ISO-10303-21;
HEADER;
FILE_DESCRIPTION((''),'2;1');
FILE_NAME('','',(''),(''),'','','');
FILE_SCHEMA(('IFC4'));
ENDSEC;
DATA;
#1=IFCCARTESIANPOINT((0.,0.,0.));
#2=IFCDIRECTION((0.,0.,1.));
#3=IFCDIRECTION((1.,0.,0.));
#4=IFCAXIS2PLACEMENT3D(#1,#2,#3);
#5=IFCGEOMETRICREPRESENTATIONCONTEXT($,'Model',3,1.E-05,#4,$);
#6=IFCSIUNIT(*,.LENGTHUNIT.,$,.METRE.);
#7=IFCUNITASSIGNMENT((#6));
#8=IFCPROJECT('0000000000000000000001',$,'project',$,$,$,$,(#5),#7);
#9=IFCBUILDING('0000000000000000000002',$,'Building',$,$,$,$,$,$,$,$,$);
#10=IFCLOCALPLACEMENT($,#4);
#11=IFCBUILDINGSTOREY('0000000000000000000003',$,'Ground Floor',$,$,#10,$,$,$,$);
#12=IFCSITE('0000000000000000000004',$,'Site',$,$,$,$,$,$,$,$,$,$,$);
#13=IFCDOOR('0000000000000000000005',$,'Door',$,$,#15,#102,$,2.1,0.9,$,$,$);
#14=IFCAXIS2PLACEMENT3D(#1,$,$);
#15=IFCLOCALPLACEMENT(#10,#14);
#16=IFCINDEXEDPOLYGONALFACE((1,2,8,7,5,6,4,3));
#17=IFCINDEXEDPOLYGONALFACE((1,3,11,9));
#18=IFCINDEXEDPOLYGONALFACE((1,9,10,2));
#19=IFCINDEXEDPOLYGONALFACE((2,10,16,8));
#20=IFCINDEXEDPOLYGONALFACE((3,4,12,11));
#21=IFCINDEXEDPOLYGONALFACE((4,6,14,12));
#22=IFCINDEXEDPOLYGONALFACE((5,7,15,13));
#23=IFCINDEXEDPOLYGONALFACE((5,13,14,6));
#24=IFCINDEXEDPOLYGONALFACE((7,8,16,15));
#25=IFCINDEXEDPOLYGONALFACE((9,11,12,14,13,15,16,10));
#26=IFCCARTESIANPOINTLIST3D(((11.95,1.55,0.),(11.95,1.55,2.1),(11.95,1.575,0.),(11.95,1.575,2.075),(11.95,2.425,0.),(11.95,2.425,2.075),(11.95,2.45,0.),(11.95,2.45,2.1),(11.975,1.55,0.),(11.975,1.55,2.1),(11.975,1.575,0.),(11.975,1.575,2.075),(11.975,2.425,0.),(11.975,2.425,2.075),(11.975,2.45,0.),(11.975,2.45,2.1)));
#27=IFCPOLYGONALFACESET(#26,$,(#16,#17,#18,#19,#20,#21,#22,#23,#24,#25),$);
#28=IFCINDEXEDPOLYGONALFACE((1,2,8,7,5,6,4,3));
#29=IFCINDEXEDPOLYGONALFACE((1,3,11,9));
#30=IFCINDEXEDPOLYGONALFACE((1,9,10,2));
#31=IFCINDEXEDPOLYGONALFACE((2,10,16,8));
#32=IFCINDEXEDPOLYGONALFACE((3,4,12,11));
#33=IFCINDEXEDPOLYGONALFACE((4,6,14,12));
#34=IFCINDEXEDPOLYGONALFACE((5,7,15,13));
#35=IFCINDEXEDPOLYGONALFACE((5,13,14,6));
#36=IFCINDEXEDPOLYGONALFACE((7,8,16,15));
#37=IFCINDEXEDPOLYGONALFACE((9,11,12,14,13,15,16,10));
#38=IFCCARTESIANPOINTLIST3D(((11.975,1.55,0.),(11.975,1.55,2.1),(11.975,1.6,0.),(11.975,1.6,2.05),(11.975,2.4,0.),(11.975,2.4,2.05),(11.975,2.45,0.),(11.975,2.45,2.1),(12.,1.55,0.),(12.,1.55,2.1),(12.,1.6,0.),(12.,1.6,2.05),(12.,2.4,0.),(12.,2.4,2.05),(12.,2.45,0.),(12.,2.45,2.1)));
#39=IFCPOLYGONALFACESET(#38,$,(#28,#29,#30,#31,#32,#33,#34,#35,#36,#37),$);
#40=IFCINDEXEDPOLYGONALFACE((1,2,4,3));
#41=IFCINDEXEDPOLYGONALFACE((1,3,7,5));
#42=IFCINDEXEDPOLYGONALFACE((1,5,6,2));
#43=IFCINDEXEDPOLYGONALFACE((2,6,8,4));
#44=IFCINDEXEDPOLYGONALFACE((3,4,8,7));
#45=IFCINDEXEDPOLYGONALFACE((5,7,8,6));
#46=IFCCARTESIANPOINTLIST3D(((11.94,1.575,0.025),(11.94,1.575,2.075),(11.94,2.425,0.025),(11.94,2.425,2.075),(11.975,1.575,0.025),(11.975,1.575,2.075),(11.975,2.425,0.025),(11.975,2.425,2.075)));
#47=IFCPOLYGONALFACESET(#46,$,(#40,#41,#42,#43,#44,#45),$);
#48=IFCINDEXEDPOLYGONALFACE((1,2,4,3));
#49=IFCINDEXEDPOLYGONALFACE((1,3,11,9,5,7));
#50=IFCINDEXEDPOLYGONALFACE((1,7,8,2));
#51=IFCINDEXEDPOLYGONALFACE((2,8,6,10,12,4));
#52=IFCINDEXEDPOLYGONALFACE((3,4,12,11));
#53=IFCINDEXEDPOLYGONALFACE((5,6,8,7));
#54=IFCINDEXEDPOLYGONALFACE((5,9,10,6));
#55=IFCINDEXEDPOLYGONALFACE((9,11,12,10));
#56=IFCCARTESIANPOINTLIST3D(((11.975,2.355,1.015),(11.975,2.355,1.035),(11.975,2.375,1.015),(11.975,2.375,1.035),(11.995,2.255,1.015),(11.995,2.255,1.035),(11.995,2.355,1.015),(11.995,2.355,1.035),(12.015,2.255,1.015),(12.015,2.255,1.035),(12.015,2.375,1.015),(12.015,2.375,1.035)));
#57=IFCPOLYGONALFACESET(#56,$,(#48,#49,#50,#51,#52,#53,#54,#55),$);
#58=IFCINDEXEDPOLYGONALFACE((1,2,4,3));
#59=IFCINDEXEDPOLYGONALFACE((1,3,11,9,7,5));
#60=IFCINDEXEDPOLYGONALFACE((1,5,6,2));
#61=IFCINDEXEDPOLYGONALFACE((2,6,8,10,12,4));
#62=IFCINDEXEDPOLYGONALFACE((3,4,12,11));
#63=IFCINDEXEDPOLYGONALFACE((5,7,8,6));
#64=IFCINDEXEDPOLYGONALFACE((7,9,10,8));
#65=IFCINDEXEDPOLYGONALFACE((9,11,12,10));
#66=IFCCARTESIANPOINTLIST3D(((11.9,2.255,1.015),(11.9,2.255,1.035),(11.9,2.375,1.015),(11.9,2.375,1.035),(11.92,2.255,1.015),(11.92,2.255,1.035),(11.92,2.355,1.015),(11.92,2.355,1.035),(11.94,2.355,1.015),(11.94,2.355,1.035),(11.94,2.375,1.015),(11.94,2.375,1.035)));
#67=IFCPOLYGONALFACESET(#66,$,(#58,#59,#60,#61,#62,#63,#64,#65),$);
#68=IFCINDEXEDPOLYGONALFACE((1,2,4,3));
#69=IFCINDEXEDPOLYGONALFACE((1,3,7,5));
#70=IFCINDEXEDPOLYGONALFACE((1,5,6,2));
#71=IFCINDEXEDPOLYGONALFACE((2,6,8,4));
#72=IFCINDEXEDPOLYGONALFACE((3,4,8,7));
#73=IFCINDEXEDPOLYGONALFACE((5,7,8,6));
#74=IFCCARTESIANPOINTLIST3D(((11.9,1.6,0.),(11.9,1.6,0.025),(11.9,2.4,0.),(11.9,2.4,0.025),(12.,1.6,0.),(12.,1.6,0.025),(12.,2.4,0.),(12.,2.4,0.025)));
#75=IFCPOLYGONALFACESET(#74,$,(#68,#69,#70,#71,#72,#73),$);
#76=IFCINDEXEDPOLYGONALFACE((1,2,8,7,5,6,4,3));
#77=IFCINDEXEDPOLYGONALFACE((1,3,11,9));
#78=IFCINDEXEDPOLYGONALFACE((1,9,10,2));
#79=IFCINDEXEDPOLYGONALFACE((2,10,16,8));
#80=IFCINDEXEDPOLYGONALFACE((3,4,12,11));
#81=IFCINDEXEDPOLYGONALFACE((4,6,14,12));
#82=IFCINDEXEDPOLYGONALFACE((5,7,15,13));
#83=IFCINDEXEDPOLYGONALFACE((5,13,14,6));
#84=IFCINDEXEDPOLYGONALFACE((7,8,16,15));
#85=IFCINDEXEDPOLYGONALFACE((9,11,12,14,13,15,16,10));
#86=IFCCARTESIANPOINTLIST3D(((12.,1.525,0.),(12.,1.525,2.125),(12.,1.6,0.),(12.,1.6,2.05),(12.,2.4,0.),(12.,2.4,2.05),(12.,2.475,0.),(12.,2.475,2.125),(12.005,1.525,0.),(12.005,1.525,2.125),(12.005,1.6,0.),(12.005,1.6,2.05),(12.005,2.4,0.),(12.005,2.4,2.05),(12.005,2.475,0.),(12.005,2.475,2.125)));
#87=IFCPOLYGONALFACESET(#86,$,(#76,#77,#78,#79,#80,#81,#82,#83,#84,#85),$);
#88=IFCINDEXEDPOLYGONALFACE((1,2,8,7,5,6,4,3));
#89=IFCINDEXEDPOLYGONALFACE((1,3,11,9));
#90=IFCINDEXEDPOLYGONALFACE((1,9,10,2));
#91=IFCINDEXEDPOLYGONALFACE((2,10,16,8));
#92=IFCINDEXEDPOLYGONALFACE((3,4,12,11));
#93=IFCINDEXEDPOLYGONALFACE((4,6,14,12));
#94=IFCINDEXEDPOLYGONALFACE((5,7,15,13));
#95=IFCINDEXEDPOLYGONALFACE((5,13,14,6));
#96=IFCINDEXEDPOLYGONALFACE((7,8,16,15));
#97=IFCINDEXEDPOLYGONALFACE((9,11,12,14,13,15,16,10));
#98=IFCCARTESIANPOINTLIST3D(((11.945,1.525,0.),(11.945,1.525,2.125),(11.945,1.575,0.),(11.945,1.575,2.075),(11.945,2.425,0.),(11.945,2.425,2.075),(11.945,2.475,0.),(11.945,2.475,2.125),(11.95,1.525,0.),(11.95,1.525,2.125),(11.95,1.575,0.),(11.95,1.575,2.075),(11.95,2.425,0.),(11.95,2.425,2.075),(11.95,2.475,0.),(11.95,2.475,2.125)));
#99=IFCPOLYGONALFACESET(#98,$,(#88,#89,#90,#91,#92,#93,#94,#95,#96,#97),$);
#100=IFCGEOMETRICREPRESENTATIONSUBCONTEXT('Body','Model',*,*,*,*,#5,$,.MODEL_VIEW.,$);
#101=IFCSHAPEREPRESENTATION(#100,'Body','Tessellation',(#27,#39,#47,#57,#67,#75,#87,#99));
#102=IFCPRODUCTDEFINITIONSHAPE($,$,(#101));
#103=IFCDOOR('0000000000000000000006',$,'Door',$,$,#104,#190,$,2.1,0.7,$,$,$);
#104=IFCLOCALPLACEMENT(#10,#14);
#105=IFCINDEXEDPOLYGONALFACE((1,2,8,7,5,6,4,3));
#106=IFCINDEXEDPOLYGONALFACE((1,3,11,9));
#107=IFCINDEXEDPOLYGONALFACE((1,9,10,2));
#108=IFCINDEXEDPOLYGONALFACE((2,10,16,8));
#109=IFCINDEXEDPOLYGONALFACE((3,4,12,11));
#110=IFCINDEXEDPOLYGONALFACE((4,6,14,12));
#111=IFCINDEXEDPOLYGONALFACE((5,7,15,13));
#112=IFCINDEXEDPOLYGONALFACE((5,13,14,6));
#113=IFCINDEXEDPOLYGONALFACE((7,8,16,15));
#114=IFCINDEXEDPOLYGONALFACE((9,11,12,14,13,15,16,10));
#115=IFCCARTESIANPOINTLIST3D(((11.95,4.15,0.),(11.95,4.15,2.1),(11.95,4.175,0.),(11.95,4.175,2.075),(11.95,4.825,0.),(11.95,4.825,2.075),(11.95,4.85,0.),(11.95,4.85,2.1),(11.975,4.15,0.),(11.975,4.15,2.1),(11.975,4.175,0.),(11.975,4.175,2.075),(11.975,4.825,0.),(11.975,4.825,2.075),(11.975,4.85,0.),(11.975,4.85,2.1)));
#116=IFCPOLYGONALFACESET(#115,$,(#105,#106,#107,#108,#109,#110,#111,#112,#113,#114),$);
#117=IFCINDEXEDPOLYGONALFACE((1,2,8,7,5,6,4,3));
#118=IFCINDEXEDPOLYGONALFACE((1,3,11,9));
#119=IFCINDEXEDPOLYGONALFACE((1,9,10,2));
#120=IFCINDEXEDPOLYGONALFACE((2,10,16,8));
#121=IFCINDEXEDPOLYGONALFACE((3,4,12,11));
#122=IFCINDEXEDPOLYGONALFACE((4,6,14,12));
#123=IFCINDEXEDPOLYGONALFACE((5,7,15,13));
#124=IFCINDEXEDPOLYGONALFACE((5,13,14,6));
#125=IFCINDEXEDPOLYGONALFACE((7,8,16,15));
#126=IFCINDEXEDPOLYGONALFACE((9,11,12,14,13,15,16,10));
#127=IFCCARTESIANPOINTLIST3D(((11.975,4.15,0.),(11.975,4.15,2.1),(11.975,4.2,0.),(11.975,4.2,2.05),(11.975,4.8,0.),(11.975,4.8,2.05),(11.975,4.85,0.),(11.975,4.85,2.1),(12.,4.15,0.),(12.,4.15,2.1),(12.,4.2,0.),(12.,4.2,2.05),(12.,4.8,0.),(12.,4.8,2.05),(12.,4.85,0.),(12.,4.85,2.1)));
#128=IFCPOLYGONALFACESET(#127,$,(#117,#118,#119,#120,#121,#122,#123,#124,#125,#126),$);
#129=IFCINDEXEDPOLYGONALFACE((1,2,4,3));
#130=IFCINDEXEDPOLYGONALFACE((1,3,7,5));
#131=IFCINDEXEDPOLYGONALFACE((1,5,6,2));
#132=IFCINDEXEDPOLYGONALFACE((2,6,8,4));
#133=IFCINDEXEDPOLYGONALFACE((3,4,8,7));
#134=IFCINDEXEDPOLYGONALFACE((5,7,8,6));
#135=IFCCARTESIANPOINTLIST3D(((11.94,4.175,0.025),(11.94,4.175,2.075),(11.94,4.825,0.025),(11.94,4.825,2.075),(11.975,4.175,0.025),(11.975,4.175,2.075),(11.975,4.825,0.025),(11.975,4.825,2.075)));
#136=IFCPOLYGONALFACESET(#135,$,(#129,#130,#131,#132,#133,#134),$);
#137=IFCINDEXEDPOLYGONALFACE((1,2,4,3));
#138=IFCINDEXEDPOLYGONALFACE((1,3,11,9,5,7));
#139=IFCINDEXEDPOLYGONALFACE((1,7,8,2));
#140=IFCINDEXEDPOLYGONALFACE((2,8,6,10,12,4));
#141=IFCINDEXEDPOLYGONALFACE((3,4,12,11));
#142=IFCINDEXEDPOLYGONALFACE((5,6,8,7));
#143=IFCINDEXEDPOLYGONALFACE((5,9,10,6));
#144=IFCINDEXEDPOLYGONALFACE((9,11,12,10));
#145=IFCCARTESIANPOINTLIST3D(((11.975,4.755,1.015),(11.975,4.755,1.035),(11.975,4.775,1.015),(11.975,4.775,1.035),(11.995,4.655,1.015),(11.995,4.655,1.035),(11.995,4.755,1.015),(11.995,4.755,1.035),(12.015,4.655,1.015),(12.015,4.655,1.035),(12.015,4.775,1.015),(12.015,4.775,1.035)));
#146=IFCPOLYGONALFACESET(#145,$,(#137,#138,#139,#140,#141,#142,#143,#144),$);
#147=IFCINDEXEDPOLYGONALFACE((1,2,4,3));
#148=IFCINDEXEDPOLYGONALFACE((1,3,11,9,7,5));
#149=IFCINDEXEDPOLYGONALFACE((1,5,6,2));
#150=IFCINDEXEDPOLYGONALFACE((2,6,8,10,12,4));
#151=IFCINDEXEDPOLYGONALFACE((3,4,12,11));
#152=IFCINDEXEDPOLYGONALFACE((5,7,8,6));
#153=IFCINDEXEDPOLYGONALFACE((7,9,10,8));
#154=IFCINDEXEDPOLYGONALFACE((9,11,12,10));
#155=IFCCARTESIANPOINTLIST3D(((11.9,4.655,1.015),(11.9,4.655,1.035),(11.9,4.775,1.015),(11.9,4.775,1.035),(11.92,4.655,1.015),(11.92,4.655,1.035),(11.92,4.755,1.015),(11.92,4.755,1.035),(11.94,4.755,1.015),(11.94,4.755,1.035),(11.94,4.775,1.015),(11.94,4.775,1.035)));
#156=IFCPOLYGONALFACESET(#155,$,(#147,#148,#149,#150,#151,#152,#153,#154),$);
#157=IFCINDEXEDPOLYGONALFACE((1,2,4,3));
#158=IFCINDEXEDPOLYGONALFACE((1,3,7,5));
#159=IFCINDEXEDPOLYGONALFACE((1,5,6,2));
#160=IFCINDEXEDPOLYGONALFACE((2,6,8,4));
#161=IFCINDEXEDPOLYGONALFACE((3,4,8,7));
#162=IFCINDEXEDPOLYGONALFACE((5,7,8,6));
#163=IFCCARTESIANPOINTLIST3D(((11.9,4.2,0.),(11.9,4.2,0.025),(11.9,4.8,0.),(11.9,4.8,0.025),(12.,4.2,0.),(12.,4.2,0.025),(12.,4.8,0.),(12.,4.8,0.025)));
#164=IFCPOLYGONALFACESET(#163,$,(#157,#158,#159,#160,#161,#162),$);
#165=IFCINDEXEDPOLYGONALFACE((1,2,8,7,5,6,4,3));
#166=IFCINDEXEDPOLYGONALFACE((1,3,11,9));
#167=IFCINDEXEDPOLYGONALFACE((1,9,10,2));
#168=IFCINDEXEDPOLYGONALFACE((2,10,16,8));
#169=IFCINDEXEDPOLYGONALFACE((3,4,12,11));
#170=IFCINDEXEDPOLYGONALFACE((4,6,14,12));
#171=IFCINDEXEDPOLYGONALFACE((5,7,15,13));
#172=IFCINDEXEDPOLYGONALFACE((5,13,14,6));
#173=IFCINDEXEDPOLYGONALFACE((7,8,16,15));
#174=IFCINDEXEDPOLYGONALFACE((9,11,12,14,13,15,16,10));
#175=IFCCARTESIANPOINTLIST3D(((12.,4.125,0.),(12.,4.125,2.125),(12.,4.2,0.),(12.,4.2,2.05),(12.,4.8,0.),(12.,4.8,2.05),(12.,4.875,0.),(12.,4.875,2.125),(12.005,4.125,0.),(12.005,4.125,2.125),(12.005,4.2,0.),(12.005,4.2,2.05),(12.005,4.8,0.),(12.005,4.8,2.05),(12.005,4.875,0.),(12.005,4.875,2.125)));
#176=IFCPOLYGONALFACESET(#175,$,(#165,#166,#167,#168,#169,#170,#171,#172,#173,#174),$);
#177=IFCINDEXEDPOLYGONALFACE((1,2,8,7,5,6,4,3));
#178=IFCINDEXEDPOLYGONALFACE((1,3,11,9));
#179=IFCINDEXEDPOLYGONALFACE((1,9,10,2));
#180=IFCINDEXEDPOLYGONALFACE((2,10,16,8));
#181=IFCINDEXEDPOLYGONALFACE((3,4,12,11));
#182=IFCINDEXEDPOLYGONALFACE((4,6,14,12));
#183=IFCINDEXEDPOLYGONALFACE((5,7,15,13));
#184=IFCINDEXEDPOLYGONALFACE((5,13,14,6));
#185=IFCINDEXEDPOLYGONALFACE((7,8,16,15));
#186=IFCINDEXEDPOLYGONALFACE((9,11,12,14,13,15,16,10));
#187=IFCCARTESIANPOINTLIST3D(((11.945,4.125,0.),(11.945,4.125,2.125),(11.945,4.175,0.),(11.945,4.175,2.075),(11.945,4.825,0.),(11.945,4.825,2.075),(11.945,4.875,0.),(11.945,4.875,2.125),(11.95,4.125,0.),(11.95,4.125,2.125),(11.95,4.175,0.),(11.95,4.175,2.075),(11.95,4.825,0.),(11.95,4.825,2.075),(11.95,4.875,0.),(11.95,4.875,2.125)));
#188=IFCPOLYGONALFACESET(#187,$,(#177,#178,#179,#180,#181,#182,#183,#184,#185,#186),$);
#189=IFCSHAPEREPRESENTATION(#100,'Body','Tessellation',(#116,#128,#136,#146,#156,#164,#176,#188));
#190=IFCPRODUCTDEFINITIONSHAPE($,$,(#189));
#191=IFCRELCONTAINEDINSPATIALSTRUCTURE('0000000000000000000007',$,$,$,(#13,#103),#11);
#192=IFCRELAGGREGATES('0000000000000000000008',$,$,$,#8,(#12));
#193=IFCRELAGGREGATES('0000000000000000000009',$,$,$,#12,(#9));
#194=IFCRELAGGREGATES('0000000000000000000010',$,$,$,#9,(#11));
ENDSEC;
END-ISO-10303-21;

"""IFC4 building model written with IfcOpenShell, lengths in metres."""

from ifc_helpers import new_model, si_unit, frame, origin_with_axes, place, context, subcontext, project, spatial, line, indexed_curve, outline, extrude, element, save


model = new_model("IFC4")

# Units and contexts
model_context = context("Model", 3, precision=1e-05, world=origin_with_axes())
body_context = subcontext(model_context, "Body", "Model", "MODEL_VIEW")
ifc_project = project(units=[si_unit("LENGTHUNIT", "METRE")], contexts=[model_context])

# Site, building, storey
site = spatial("IfcSite", under=ifc_project, Name="Site")
building = spatial("IfcBuilding", under=site, Name="Building")
storey_placement = place(None, origin_with_axes())
storey = spatial("IfcBuildingStorey", under=building, at=storey_placement, Name="Ground Floor")

# Doors
door_1_placement = place(storey_placement, frame((12.0, 1.55, 0.0), z_axis=(0.0, 0.0, 1.0), x_axis=(0.0, 1.0, 0.0)))
element("IfcDoor", 1, at=door_1_placement, inside=storey, Name="Door", OverallHeight=2.1, OverallWidth=0.9, context=body_context, shape_type="SweptSolid", body=[
    extrude(outline(indexed_curve([(0.0, 0.0), (0.0, 2.1), (0.9, 2.1), (0.9, 0.0), (0.875, 0.0), (0.875, 2.075), (0.025, 2.075), (0.025, 0.0)], segments=[line(1, 2, 3, 4, 5, 6, 7, 8, 1)])), frame((0.0, 0.025, 0.0), z_axis=(0.0, -1.0, 0.0), x_axis=(1.0, 0.0, 0.0)), (0.0, 0.0, -1.0), 0.025),
    extrude(outline(indexed_curve([(0.0, 0.0), (0.0, 2.1), (0.9, 2.1), (0.9, 0.0), (0.85, 0.0), (0.85, 2.05), (0.05, 2.05), (0.05, 0.0)], segments=[line(1, 2, 3, 4, 5, 6, 7, 8, 1)])), frame((0.0, 0.0, 0.0), z_axis=(0.0, -1.0, 0.0), x_axis=(1.0, 0.0, 0.0)), (0.0, 0.0, -1.0), 0.025),
    extrude(outline(indexed_curve([(0.0, 0.0), (0.85, 0.0), (0.85, 0.035), (0.0, 0.035)], segments=[line(1, 2, 3, 4, 1)])), frame((0.025, 0.025, 0.025), z_axis=(0.0, 0.0, 1.0), x_axis=(1.0, 0.0, 0.0)), (0.0, 0.0, 1.0), 2.05),
    extrude(outline(indexed_curve([(0.0, 0.0), (0.0, -0.04), (-0.12, -0.04), (-0.12, -0.02), (-0.02, -0.02), (-0.02, 0.0)], segments=[line(1, 2, 3, 4, 5, 6, 1)])), frame((0.825, 0.025, 1.015), z_axis=(0.0, 0.0, 1.0), x_axis=(1.0, 0.0, 0.0)), (0.0, 0.0, 1.0), 0.02),
    extrude(outline(indexed_curve([(0.0, 0.0), (0.0, 0.04), (-0.12, 0.04), (-0.12, 0.02), (-0.02, 0.02), (-0.02, 0.0)], segments=[line(1, 2, 3, 4, 5, 6, 1)])), frame((0.825, 0.06, 1.015), z_axis=(0.0, 0.0, 1.0), x_axis=(1.0, 0.0, 0.0)), (0.0, 0.0, 1.0), 0.02),
    extrude(outline(indexed_curve([(0.0, 0.0), (0.8, 0.0), (0.8, 0.1), (0.0, 0.1)], segments=[line(1, 2, 3, 4, 1)])), frame((0.05, 0.0, 0.0), z_axis=(0.0, 0.0, 1.0), x_axis=(1.0, 0.0, 0.0)), (0.0, 0.0, 1.0), 0.025),
    extrude(outline(indexed_curve([(0.0, 0.0), (0.0, 2.125), (0.95, 2.125), (0.95, 0.0), (0.875, 0.0), (0.875, 2.05), (0.075, 2.05), (0.075, 0.0)], segments=[line(1, 2, 3, 4, 5, 6, 7, 8, 1)])), frame((-0.025, -0.005, 0.0), z_axis=(0.0, -1.0, 0.0), x_axis=(1.0, 0.0, 0.0)), (0.0, 0.0, -1.0), 0.005),
    extrude(outline(indexed_curve([(0.0, 0.0), (0.0, 2.125), (0.95, 2.125), (0.95, 0.0), (0.9, 0.0), (0.9, 2.075), (0.05, 2.075), (0.05, 0.0)], segments=[line(1, 2, 3, 4, 5, 6, 7, 8, 1)])), frame((-0.025, 0.05, 0.0), z_axis=(0.0, -1.0, 0.0), x_axis=(1.0, 0.0, 0.0)), (0.0, 0.0, -1.0), 0.005),
])
door_2_placement = place(storey_placement, frame((12.0, 4.15, 0.0), z_axis=(0.0, 0.0, 1.0), x_axis=(0.0, 1.0, 0.0)))
element("IfcDoor", 2, at=door_2_placement, inside=storey, Name="Door", OverallHeight=2.1, OverallWidth=0.7, context=body_context, shape_type="SweptSolid", body=[
    extrude(outline(indexed_curve([(0.0, 0.0), (0.0, 2.1), (0.7, 2.1), (0.7, 0.0), (0.675, 0.0), (0.675, 2.075), (0.025, 2.075), (0.025, 0.0)], segments=[line(1, 2, 3, 4, 5, 6, 7, 8, 1)])), frame((0.0, 0.025, 0.0), z_axis=(0.0, -1.0, 0.0), x_axis=(1.0, 0.0, 0.0)), (0.0, 0.0, -1.0), 0.025),
    extrude(outline(indexed_curve([(0.0, 0.0), (0.0, 2.1), (0.7, 2.1), (0.7, 0.0), (0.65, 0.0), (0.65, 2.05), (0.05, 2.05), (0.05, 0.0)], segments=[line(1, 2, 3, 4, 5, 6, 7, 8, 1)])), frame((0.0, 0.0, 0.0), z_axis=(0.0, -1.0, 0.0), x_axis=(1.0, 0.0, 0.0)), (0.0, 0.0, -1.0), 0.025),
    extrude(outline(indexed_curve([(0.0, 0.0), (0.65, 0.0), (0.65, 0.035), (0.0, 0.035)], segments=[line(1, 2, 3, 4, 1)])), frame((0.025, 0.025, 0.025), z_axis=(0.0, 0.0, 1.0), x_axis=(1.0, 0.0, 0.0)), (0.0, 0.0, 1.0), 2.05),
    extrude(outline(indexed_curve([(0.0, 0.0), (0.0, -0.04), (-0.12, -0.04), (-0.12, -0.02), (-0.02, -0.02), (-0.02, 0.0)], segments=[line(1, 2, 3, 4, 5, 6, 1)])), frame((0.625, 0.025, 1.015), z_axis=(0.0, 0.0, 1.0), x_axis=(1.0, 0.0, 0.0)), (0.0, 0.0, 1.0), 0.02),
    extrude(outline(indexed_curve([(0.0, 0.0), (0.0, 0.04), (-0.12, 0.04), (-0.12, 0.02), (-0.02, 0.02), (-0.02, 0.0)], segments=[line(1, 2, 3, 4, 5, 6, 1)])), frame((0.625, 0.06, 1.015), z_axis=(0.0, 0.0, 1.0), x_axis=(1.0, 0.0, 0.0)), (0.0, 0.0, 1.0), 0.02),
    extrude(outline(indexed_curve([(0.0, 0.0), (0.6, 0.0), (0.6, 0.1), (0.0, 0.1)], segments=[line(1, 2, 3, 4, 1)])), frame((0.05, 0.0, 0.0), z_axis=(0.0, 0.0, 1.0), x_axis=(1.0, 0.0, 0.0)), (0.0, 0.0, 1.0), 0.025),
    extrude(outline(indexed_curve([(0.0, 0.0), (0.0, 2.125), (0.75, 2.125), (0.75, 0.0), (0.675, 0.0), (0.675, 2.05), (0.075, 2.05), (0.075, 0.0)], segments=[line(1, 2, 3, 4, 5, 6, 7, 8, 1)])), frame((-0.025, -0.005, 0.0), z_axis=(0.0, -1.0, 0.0), x_axis=(1.0, 0.0, 0.0)), (0.0, 0.0, -1.0), 0.005),
    extrude(outline(indexed_curve([(0.0, 0.0), (0.0, 2.125), (0.75, 2.125), (0.75, 0.0), (0.7, 0.0), (0.7, 2.075), (0.05, 2.075), (0.05, 0.0)], segments=[line(1, 2, 3, 4, 5, 6, 7, 8, 1)])), frame((-0.025, 0.05, 0.0), z_axis=(0.0, -1.0, 0.0), x_axis=(1.0, 0.0, 0.0)), (0.0, 0.0, -1.0), 0.005),
])

save(model, "model.ifc")
